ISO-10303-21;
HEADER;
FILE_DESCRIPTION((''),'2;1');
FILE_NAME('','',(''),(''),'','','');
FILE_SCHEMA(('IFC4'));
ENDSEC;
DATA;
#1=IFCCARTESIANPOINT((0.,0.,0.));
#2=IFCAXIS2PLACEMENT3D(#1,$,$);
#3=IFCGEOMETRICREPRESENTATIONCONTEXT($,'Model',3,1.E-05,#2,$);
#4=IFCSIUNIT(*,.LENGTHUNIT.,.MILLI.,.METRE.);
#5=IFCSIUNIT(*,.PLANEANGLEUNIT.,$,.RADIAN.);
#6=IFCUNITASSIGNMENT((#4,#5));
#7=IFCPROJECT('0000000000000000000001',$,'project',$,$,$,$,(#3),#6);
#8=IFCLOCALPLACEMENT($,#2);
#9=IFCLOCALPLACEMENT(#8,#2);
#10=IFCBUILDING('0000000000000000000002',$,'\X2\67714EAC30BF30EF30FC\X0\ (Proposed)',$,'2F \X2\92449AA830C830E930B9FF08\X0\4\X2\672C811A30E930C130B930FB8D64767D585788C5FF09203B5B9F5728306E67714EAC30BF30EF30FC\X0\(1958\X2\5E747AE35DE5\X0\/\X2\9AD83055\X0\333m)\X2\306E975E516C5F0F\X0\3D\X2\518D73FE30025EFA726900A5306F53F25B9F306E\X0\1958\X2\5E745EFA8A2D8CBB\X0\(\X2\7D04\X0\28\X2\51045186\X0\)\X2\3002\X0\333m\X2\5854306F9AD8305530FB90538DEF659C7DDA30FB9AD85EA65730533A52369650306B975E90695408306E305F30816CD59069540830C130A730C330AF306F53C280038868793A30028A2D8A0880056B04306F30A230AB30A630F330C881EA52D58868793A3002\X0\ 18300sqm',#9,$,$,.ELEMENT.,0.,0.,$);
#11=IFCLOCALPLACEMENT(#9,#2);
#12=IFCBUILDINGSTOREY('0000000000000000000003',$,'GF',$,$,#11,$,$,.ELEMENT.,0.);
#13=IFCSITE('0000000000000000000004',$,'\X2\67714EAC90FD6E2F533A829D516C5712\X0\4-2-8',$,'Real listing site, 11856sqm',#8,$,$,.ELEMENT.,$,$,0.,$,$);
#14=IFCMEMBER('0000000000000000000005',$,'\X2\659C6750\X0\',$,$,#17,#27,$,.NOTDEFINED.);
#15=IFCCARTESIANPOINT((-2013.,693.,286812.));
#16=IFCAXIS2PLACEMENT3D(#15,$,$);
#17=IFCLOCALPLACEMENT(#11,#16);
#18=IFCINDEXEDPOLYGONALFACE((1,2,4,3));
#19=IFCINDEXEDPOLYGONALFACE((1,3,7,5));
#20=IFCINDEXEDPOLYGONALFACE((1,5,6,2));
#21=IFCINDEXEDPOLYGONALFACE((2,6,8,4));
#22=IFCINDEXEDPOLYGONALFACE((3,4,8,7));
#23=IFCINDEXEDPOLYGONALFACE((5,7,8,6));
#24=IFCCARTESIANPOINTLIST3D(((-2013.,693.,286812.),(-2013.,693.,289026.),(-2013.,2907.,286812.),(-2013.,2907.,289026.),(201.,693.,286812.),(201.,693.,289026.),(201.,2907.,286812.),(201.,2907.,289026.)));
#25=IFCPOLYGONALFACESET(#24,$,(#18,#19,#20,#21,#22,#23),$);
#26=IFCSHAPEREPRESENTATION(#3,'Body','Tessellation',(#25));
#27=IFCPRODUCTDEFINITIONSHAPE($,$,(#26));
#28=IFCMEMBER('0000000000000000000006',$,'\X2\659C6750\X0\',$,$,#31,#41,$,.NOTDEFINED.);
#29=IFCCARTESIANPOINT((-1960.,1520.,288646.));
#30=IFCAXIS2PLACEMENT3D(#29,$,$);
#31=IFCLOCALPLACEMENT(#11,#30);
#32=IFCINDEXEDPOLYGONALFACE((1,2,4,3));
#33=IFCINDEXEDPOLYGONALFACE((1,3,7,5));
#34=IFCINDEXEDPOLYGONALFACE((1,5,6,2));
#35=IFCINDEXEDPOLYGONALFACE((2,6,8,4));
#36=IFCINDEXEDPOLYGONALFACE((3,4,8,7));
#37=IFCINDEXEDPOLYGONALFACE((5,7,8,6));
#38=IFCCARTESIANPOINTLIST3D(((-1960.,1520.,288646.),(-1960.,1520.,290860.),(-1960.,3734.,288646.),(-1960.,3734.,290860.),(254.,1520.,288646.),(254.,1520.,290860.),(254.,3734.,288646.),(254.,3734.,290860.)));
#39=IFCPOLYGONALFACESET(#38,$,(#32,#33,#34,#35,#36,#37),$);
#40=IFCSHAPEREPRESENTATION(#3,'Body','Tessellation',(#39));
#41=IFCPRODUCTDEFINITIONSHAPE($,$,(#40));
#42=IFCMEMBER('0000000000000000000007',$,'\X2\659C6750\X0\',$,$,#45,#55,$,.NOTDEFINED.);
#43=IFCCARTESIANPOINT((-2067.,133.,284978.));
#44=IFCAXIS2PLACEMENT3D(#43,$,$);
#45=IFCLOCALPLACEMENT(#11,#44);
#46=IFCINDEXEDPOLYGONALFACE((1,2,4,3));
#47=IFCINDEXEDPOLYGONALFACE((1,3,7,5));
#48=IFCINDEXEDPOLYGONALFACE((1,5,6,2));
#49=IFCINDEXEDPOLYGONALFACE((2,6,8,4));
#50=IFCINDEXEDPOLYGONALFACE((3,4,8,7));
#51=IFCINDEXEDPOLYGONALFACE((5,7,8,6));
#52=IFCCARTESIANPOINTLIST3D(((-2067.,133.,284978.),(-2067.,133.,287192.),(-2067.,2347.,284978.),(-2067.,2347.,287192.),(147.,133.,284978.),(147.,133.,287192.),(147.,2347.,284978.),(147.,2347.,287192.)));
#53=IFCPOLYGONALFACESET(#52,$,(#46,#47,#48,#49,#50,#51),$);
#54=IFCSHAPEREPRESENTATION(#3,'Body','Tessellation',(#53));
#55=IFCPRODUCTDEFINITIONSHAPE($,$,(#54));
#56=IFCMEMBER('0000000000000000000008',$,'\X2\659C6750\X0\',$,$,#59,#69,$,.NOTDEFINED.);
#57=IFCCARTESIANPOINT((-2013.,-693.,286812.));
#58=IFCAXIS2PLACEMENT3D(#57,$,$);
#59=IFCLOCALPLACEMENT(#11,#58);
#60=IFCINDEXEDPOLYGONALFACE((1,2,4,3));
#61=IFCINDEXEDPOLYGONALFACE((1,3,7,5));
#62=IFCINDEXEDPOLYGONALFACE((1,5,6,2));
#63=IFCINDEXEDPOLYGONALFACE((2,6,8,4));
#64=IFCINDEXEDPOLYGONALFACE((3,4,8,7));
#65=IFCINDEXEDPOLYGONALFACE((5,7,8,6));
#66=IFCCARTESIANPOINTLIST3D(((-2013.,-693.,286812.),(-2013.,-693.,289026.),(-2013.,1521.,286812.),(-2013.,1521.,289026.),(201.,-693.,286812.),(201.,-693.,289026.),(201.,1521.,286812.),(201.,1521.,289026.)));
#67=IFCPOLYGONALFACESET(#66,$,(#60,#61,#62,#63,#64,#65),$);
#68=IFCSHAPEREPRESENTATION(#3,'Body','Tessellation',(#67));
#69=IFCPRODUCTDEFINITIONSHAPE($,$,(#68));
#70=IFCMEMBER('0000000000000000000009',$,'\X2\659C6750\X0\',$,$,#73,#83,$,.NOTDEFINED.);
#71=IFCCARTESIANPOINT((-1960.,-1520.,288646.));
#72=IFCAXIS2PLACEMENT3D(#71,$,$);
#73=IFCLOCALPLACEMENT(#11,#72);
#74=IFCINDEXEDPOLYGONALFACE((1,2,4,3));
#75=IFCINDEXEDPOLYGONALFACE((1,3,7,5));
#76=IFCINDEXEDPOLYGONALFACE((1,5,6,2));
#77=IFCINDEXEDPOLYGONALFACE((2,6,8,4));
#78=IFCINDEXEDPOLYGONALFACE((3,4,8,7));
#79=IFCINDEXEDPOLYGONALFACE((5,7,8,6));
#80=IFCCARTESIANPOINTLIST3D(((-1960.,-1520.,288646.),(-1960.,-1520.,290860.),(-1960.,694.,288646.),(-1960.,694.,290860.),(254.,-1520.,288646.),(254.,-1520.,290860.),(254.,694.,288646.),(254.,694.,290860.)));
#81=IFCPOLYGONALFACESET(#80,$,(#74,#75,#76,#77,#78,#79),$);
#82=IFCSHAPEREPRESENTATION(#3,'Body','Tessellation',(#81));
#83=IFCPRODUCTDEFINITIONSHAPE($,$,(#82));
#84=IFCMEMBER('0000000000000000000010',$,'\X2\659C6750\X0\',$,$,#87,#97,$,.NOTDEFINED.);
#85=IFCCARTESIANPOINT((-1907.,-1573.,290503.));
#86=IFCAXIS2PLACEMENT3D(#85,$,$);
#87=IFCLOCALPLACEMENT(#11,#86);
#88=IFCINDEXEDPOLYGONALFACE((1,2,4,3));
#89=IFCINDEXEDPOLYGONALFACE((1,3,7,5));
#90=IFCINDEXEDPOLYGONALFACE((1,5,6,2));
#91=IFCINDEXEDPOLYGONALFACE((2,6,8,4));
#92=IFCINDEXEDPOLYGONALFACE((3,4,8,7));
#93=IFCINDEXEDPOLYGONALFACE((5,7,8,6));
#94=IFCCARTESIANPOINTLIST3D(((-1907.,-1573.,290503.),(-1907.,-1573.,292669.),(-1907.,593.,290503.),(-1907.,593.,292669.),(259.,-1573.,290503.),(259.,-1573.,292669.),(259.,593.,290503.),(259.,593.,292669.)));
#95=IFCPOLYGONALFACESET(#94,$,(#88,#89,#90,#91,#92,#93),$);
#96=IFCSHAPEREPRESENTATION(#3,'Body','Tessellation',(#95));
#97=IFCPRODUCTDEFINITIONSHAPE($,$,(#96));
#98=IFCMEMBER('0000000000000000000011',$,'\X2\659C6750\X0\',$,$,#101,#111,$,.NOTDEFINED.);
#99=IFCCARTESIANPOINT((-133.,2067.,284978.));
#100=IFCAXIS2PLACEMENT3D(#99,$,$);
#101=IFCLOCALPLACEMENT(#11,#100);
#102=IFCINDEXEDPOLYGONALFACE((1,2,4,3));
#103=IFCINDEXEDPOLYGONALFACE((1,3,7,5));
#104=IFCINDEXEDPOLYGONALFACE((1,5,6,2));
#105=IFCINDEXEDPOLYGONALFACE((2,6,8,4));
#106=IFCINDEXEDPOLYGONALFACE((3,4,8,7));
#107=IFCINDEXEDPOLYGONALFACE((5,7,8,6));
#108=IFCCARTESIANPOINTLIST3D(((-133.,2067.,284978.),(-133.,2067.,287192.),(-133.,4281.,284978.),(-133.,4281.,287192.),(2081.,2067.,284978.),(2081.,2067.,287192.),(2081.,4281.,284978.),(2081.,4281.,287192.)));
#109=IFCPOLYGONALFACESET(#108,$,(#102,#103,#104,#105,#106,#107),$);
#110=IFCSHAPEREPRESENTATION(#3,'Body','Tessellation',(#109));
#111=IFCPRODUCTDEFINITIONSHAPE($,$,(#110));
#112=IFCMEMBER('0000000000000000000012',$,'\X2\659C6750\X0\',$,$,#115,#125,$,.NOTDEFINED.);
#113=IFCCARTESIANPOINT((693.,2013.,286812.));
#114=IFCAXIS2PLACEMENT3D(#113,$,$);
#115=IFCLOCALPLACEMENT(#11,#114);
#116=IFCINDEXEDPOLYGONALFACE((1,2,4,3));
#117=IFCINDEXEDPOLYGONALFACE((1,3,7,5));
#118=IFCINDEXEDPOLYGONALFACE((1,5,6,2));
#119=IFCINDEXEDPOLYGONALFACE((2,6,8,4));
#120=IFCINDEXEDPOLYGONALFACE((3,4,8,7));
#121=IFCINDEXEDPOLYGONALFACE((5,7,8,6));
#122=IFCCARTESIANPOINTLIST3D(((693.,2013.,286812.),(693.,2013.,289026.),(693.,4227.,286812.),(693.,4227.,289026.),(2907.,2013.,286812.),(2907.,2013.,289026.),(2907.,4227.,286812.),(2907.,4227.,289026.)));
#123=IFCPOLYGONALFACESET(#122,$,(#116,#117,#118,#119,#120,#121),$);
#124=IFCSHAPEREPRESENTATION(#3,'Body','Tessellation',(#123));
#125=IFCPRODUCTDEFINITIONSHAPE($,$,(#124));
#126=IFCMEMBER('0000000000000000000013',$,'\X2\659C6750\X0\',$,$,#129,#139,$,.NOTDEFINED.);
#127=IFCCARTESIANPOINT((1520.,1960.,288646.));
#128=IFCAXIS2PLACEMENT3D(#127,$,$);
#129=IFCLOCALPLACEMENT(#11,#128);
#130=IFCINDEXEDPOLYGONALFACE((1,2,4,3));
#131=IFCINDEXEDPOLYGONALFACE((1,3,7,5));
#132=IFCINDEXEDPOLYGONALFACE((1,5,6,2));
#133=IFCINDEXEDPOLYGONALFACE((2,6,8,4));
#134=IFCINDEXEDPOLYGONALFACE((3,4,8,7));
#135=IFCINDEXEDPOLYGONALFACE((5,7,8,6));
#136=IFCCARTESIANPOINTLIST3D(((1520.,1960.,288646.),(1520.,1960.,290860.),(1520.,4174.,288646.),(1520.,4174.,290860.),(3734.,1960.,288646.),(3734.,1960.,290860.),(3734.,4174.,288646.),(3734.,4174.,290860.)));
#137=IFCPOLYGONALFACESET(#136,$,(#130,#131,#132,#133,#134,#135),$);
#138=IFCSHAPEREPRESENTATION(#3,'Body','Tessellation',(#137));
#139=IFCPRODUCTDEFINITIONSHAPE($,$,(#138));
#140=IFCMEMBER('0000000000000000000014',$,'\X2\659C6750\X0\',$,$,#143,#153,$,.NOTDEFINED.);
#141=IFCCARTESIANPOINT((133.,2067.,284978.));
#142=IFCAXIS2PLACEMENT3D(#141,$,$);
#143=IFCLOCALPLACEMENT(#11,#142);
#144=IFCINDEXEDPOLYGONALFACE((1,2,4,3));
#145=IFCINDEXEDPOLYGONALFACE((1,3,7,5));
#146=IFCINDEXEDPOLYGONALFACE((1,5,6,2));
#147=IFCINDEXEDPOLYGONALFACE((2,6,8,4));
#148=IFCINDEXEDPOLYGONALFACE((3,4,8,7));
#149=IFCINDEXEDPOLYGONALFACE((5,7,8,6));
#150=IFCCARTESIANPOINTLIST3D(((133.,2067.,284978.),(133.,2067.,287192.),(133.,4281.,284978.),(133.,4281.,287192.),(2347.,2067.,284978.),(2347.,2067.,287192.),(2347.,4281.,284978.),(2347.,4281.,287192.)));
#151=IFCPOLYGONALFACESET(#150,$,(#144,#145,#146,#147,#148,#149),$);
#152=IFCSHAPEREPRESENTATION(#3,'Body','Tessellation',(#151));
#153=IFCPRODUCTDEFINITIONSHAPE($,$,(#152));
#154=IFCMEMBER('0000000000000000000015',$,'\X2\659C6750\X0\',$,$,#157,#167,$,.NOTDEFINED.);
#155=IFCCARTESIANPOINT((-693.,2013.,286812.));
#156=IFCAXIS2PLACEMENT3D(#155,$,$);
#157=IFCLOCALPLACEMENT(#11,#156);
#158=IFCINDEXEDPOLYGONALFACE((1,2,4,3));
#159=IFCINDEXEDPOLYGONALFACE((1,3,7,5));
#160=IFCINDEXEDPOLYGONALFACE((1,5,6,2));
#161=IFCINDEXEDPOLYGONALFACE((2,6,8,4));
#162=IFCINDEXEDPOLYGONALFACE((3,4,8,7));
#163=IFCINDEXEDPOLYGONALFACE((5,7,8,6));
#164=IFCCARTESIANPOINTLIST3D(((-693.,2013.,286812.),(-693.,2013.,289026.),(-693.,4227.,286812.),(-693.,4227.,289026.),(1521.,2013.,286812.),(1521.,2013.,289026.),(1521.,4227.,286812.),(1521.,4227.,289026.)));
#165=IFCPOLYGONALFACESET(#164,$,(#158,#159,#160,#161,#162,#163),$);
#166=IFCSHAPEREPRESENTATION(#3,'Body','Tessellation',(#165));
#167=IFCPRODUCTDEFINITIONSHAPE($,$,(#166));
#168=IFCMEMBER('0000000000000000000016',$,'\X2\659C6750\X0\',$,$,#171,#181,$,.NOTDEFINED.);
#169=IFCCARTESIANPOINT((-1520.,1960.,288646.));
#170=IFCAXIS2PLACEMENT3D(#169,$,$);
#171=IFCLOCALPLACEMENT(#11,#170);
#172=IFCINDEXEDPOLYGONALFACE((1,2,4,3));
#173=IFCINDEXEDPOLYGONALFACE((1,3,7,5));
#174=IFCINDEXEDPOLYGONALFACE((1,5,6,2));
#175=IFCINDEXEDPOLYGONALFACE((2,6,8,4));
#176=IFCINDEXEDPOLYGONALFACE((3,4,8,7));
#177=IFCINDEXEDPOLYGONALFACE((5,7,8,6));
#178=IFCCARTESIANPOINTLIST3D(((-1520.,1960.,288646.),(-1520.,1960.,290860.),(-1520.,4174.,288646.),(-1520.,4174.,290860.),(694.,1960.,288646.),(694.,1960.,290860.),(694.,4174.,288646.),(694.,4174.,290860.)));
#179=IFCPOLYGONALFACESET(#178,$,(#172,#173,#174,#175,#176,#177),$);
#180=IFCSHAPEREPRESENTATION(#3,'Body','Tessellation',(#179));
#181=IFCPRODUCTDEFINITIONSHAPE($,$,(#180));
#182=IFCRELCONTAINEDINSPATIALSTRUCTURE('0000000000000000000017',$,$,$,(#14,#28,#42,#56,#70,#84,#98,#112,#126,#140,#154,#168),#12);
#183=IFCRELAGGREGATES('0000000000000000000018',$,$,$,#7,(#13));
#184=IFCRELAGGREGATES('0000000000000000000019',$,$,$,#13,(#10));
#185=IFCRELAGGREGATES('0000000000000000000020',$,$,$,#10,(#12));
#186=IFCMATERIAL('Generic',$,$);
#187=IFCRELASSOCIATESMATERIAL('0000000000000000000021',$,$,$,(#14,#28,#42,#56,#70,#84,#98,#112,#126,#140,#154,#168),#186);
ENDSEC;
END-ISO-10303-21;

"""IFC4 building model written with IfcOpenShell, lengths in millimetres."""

from ifc_helpers import new_model, si_unit, frame, frame_2d, origin, place, context, project, spatial, rectangle, extrude, material, element, save


model = new_model("IFC4")

# Units and contexts
model_context = context("Model", 3, precision=1e-05, world=origin())
ifc_project = project(units=[si_unit("LENGTHUNIT", "METRE", prefix="MILLI"), si_unit("PLANEANGLEUNIT", "RADIAN")], contexts=[model_context])

# Site, building, storey
site_placement = place(None, origin())
site = spatial("IfcSite", under=ifc_project, at=site_placement, Name="東京都港区芝公園4-2-8", ObjectType="Real listing site, 11856sqm", CompositionType="ELEMENT", RefElevation=0.0)
building_placement = place(site_placement, origin())
building = spatial("IfcBuilding", under=site, at=building_placement, Name="東京タワー (Proposed)", ObjectType="2F 鉄骨トラス（4本脚ラチス・赤白塗装）※実在の東京タワー(1958年竣工/高さ333m)の非公式3D再現。建物¥は史実の1958年建設費(約28億円)。333m塔は高さ・道路斜線・高度地区制限に非適合のため法適合チェックは参考表示。設計者欄はアカウント自動表示。 18300sqm", CompositionType="ELEMENT", ElevationOfRefHeight=0.0, ElevationOfTerrain=0.0)
storey_placement = place(building_placement, origin())
storey = spatial("IfcBuildingStorey", under=building, at=storey_placement, Name="GF", CompositionType="ELEMENT", Elevation=0.0)

# Members
ifc_material = material(Name="Generic")
member_1_placement = place(storey_placement, frame((-2013.0, 693.0, 286812.0)))
element("IfcMember", 1, at=member_1_placement, inside=storey, material=ifc_material, Name="斜材", PredefinedType="NOTDEFINED", context=model_context, shape_type="SweptSolid", body=[
    extrude(rectangle(XDim=2214.0, YDim=2214.0, at=frame_2d((1107.0, 1107.0))), frame((-2013.0, 693.0, 286812.0)), (0.0, 0.0, 1.0), 2214.0),
])
member_2_placement = place(storey_placement, frame((-1960.0, 1520.0, 288646.0)))
element("IfcMember", 2, at=member_2_placement, inside=storey, material=ifc_material, Name="斜材", PredefinedType="NOTDEFINED", context=model_context, shape_type="SweptSolid", body=[
    extrude(rectangle(XDim=2214.0, YDim=2214.0, at=frame_2d((1107.0, 1107.0))), frame((-1960.0, 1520.0, 288646.0)), (0.0, 0.0, 1.0), 2214.0),
])
member_3_placement = place(storey_placement, frame((-2067.0, 133.0, 284978.0)))
element("IfcMember", 3, at=member_3_placement, inside=storey, material=ifc_material, Name="斜材", PredefinedType="NOTDEFINED", context=model_context, shape_type="SweptSolid", body=[
    extrude(rectangle(XDim=2214.0, YDim=2214.0, at=frame_2d((1107.0, 1107.0))), frame((-2067.0, 133.0, 284978.0)), (0.0, 0.0, 1.0), 2214.0),
])
member_4_placement = place(storey_placement, frame((-2013.0, -693.0, 286812.0)))
element("IfcMember", 4, at=member_4_placement, inside=storey, material=ifc_material, Name="斜材", PredefinedType="NOTDEFINED", context=model_context, shape_type="SweptSolid", body=[
    extrude(rectangle(XDim=2214.0, YDim=2214.0, at=frame_2d((1107.0, 1107.0))), frame((-2013.0, -693.0, 286812.0)), (0.0, 0.0, 1.0), 2214.0),
])
member_5_placement = place(storey_placement, frame((-1960.0, -1520.0, 288646.0)))
element("IfcMember", 5, at=member_5_placement, inside=storey, material=ifc_material, Name="斜材", PredefinedType="NOTDEFINED", context=model_context, shape_type="SweptSolid", body=[
    extrude(rectangle(XDim=2214.0, YDim=2214.0, at=frame_2d((1107.0, 1107.0))), frame((-1960.0, -1520.0, 288646.0)), (0.0, 0.0, 1.0), 2214.0),
])
member_6_placement = place(storey_placement, frame((-1907.0, -1573.0, 290503.0)))
element("IfcMember", 6, at=member_6_placement, inside=storey, material=ifc_material, Name="斜材", PredefinedType="NOTDEFINED", context=model_context, shape_type="SweptSolid", body=[
    extrude(rectangle(XDim=2166.0, YDim=2166.0, at=frame_2d((1083.0, 1083.0))), frame((-1907.0, -1573.0, 290503.0)), (0.0, 0.0, 1.0), 2166.0),
])
member_7_placement = place(storey_placement, frame((-133.0, 2067.0, 284978.0)))
element("IfcMember", 7, at=member_7_placement, inside=storey, material=ifc_material, Name="斜材", PredefinedType="NOTDEFINED", context=model_context, shape_type="SweptSolid", body=[
    extrude(rectangle(XDim=2214.0, YDim=2214.0, at=frame_2d((1107.0, 1107.0))), frame((-133.0, 2067.0, 284978.0)), (0.0, 0.0, 1.0), 2214.0),
])
member_8_placement = place(storey_placement, frame((693.0, 2013.0, 286812.0)))
element("IfcMember", 8, at=member_8_placement, inside=storey, material=ifc_material, Name="斜材", PredefinedType="NOTDEFINED", context=model_context, shape_type="SweptSolid", body=[
    extrude(rectangle(XDim=2214.0, YDim=2214.0, at=frame_2d((1107.0, 1107.0))), frame((693.0, 2013.0, 286812.0)), (0.0, 0.0, 1.0), 2214.0),
])
member_9_placement = place(storey_placement, frame((1520.0, 1960.0, 288646.0)))
element("IfcMember", 9, at=member_9_placement, inside=storey, material=ifc_material, Name="斜材", PredefinedType="NOTDEFINED", context=model_context, shape_type="SweptSolid", body=[
    extrude(rectangle(XDim=2214.0, YDim=2214.0, at=frame_2d((1107.0, 1107.0))), frame((1520.0, 1960.0, 288646.0)), (0.0, 0.0, 1.0), 2214.0),
])
member_10_placement = place(storey_placement, frame((133.0, 2067.0, 284978.0)))
element("IfcMember", 10, at=member_10_placement, inside=storey, material=ifc_material, Name="斜材", PredefinedType="NOTDEFINED", context=model_context, shape_type="SweptSolid", body=[
    extrude(rectangle(XDim=2214.0, YDim=2214.0, at=frame_2d((1107.0, 1107.0))), frame((133.0, 2067.0, 284978.0)), (0.0, 0.0, 1.0), 2214.0),
])
member_11_placement = place(storey_placement, frame((-693.0, 2013.0, 286812.0)))
element("IfcMember", 11, at=member_11_placement, inside=storey, material=ifc_material, Name="斜材", PredefinedType="NOTDEFINED", context=model_context, shape_type="SweptSolid", body=[
    extrude(rectangle(XDim=2214.0, YDim=2214.0, at=frame_2d((1107.0, 1107.0))), frame((-693.0, 2013.0, 286812.0)), (0.0, 0.0, 1.0), 2214.0),
])
member_12_placement = place(storey_placement, frame((-1520.0, 1960.0, 288646.0)))
element("IfcMember", 12, at=member_12_placement, inside=storey, material=ifc_material, Name="斜材", PredefinedType="NOTDEFINED", context=model_context, shape_type="SweptSolid", body=[
    extrude(rectangle(XDim=2214.0, YDim=2214.0, at=frame_2d((1107.0, 1107.0))), frame((-1520.0, 1960.0, 288646.0)), (0.0, 0.0, 1.0), 2214.0),
])

save(model, "model.ifc")
